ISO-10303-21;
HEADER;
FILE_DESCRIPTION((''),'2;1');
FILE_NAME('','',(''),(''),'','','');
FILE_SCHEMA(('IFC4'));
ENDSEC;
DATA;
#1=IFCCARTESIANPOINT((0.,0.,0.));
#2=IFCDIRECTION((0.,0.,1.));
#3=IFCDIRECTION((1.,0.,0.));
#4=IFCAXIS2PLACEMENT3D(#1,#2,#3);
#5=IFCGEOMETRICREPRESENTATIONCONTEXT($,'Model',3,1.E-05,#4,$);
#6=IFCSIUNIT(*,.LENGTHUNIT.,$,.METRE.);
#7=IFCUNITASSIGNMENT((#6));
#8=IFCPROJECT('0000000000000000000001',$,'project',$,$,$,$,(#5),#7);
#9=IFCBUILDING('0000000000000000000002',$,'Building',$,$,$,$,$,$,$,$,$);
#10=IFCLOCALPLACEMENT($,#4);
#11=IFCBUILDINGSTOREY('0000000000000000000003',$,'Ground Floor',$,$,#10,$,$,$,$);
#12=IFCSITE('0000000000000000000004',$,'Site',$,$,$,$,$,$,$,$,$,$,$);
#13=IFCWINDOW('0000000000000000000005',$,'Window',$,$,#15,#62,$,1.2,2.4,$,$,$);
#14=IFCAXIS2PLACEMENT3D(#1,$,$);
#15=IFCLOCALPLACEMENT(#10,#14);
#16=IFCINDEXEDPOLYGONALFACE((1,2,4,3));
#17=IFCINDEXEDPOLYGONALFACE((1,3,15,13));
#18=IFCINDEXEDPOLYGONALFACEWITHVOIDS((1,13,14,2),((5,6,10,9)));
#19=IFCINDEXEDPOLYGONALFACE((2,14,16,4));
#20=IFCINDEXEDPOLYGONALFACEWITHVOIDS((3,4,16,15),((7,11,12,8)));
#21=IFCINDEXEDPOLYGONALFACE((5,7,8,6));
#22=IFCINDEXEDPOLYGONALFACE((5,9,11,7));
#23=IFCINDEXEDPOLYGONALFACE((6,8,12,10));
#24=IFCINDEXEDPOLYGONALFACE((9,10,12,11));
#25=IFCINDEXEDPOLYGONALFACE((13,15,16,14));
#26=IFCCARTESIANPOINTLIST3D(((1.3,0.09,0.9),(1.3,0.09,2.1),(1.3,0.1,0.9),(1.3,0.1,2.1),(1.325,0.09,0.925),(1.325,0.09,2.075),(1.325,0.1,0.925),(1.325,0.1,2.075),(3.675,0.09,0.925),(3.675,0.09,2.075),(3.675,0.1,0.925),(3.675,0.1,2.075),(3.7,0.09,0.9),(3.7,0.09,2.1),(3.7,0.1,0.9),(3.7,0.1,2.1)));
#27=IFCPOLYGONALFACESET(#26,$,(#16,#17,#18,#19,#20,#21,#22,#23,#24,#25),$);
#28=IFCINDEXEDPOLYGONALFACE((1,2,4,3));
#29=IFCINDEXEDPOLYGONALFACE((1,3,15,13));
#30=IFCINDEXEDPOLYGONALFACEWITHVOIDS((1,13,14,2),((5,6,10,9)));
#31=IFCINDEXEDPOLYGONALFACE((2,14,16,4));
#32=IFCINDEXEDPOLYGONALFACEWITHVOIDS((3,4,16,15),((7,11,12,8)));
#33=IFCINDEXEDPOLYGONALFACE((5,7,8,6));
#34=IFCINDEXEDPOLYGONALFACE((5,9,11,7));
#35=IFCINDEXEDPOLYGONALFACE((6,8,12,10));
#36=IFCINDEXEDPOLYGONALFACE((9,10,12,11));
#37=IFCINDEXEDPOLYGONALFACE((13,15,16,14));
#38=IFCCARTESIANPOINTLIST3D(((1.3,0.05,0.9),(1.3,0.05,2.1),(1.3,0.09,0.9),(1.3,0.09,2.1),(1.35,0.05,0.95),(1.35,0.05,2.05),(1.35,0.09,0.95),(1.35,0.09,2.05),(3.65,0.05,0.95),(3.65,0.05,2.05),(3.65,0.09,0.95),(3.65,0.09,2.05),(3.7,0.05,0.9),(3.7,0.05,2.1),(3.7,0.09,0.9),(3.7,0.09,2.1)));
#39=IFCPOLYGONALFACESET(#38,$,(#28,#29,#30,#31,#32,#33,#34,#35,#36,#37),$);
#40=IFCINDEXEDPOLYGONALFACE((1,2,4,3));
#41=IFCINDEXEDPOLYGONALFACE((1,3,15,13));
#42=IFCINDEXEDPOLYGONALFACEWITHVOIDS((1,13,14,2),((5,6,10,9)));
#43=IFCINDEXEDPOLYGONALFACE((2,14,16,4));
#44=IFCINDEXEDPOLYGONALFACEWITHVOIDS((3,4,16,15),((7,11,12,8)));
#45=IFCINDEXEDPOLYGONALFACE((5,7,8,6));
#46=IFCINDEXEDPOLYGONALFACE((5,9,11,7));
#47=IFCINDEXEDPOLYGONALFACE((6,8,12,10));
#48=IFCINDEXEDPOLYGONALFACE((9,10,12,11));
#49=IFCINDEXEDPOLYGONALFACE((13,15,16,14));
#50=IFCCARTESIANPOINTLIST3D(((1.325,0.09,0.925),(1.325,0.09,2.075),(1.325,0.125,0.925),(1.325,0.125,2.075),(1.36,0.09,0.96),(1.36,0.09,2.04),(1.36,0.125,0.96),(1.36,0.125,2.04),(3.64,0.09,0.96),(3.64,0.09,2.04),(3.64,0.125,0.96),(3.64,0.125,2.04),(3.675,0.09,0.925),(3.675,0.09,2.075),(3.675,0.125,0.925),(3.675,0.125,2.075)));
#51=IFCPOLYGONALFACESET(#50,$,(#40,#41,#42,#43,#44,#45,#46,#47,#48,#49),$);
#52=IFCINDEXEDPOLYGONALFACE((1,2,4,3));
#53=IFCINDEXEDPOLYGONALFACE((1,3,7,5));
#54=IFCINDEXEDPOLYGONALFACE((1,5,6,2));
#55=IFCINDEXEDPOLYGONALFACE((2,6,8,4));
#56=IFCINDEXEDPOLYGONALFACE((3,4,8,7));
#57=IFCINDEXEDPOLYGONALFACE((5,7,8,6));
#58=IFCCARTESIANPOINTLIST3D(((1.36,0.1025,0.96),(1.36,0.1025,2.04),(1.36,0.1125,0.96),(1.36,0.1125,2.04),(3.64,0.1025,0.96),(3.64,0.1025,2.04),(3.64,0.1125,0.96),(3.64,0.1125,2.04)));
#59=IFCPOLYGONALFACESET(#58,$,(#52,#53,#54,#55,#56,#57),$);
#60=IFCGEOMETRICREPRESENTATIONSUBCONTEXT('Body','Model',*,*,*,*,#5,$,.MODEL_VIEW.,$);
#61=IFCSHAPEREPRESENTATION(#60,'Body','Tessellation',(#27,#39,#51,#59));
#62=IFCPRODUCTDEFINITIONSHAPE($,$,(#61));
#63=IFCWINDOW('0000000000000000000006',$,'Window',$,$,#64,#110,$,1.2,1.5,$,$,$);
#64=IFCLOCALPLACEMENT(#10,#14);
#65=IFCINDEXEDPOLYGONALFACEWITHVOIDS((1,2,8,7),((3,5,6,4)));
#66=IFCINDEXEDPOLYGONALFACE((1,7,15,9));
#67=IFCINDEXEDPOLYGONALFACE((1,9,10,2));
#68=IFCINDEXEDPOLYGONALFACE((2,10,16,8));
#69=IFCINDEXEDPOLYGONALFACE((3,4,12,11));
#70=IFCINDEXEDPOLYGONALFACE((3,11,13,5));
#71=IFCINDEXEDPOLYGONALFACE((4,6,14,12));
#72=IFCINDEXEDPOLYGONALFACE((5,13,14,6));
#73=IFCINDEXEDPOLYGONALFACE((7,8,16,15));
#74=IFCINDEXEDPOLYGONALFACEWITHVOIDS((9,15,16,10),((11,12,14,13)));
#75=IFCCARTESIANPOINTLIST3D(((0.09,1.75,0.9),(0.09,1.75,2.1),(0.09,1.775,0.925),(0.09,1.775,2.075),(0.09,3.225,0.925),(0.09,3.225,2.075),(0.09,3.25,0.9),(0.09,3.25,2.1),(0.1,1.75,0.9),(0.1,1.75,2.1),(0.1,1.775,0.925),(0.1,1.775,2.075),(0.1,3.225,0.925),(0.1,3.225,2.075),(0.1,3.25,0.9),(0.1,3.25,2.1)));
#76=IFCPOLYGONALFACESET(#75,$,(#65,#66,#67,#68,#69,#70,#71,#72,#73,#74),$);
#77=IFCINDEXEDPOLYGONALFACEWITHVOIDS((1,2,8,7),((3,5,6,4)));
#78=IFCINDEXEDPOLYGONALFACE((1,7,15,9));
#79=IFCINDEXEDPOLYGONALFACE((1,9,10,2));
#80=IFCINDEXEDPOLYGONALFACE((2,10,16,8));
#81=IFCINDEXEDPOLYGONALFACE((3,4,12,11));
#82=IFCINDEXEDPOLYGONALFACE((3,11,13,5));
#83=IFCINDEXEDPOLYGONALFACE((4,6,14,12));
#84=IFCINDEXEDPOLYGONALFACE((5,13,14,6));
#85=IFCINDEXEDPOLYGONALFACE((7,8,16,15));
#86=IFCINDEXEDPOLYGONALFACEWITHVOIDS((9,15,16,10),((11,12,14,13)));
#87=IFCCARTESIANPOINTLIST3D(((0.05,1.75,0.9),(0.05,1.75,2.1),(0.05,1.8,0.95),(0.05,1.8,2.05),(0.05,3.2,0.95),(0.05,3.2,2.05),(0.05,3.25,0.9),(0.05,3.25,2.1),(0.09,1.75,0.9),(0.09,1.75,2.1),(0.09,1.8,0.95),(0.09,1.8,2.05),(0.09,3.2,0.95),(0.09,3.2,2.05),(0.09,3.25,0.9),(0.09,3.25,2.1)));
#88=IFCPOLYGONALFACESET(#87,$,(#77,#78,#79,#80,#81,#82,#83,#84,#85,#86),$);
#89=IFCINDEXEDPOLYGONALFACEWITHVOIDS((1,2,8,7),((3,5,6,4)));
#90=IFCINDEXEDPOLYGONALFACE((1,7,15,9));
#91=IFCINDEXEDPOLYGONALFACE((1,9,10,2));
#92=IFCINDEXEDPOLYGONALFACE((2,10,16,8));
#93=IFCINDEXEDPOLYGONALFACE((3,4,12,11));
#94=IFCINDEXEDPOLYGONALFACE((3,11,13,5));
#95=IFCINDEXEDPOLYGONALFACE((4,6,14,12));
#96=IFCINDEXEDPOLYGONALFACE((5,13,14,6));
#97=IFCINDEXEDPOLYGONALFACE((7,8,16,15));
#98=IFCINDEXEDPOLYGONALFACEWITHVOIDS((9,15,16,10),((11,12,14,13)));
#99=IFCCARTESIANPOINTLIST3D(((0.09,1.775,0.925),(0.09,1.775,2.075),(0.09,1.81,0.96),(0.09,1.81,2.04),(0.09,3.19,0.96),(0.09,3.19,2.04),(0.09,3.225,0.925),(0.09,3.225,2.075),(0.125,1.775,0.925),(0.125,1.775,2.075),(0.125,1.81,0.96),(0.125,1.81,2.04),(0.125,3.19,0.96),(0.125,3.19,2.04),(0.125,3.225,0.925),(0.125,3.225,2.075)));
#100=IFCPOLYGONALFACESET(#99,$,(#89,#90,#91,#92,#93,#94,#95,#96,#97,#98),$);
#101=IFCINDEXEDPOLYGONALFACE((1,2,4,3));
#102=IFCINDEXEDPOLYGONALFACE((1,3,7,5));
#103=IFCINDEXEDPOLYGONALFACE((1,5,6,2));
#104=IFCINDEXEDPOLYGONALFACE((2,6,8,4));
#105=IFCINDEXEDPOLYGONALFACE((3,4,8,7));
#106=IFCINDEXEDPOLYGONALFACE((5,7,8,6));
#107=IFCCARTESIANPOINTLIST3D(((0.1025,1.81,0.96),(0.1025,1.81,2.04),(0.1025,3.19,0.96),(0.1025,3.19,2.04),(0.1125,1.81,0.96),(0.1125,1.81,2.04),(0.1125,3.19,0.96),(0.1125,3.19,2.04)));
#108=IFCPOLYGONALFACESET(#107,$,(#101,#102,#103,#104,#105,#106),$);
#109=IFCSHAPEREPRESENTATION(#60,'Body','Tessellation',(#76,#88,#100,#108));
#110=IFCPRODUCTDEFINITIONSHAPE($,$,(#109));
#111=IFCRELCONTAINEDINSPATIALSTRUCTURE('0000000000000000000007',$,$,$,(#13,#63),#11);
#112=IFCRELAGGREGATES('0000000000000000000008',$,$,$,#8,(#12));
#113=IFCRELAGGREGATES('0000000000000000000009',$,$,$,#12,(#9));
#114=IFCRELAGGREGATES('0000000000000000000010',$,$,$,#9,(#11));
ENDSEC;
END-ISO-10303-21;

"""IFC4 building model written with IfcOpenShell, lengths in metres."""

from ifc_helpers import new_model, si_unit, frame, origin_with_axes, place, context, subcontext, project, spatial, line, indexed_curve, outline, extrude, element, save


model = new_model("IFC4")

# Units and contexts
model_context = context("Model", 3, precision=1e-05, world=origin_with_axes())
body_context = subcontext(model_context, "Body", "Model", "MODEL_VIEW")
ifc_project = project(units=[si_unit("LENGTHUNIT", "METRE")], contexts=[model_context])

# Site, building, storey
site = spatial("IfcSite", under=ifc_project, Name="Site")
building = spatial("IfcBuilding", under=site, Name="Building")
storey_placement = place(None, origin_with_axes())
storey = spatial("IfcBuildingStorey", under=building, at=storey_placement, Name="Ground Floor")

# Windows
window_1_placement = place(storey_placement, frame((1.3, 0.0, 0.9), z_axis=(0.0, 0.0, 1.0), x_axis=(1.0, 0.0, 0.0)))
element("IfcWindow", 1, at=window_1_placement, inside=storey, Name="Window", OverallHeight=1.2, OverallWidth=2.4, context=body_context, shape_type="SweptSolid", body=[
    extrude(outline(indexed_curve([(0.0, 0.0), (2.4, 0.0), (2.4, 1.2), (0.0, 1.2)], segments=[line(1, 2, 3, 4, 1)]), holes=[indexed_curve([(0.025, 0.025), (2.375, 0.025), (2.375, 1.175), (0.025, 1.175)], segments=[line(1, 2, 3, 4, 1)])]), frame((0.0, 0.09, 0.0), z_axis=(0.0, -1.0, 0.0), x_axis=(1.0, 0.0, 0.0)), (0.0, 0.0, -1.0), 0.01),
    extrude(outline(indexed_curve([(0.0, 0.0), (2.4, 0.0), (2.4, 1.2), (0.0, 1.2)], segments=[line(1, 2, 3, 4, 1)]), holes=[indexed_curve([(0.05, 0.05), (2.35, 0.05), (2.35, 1.15), (0.05, 1.15)], segments=[line(1, 2, 3, 4, 1)])]), frame((0.0, 0.05, 0.0), z_axis=(0.0, -1.0, 0.0), x_axis=(1.0, 0.0, 0.0)), (0.0, 0.0, -1.0), 0.04),
    extrude(outline(indexed_curve([(0.0, 0.0), (2.35, 0.0), (2.35, 1.15), (0.0, 1.15)], segments=[line(1, 2, 3, 4, 1)]), holes=[indexed_curve([(0.035, 0.035), (2.315, 0.035), (2.315, 1.115), (0.035, 1.115)], segments=[line(1, 2, 3, 4, 1)])]), frame((0.025, 0.09, 0.025), z_axis=(0.0, -1.0, 0.0), x_axis=(1.0, 0.0, 0.0)), (0.0, 0.0, -1.0), 0.035),
    extrude(outline(indexed_curve([(0.035, 0.035), (2.315, 0.035), (2.315, 1.115), (0.035, 1.115)], segments=[line(1, 2, 3, 4, 1)])), frame((0.025, 0.1025, 0.025), z_axis=(0.0, -1.0, 0.0), x_axis=(1.0, 0.0, 0.0)), (0.0, 0.0, -1.0), 0.01),
])
window_2_placement = place(storey_placement, frame((0.0, 3.25, 0.9), z_axis=(0.0, 0.0, 1.0), x_axis=(0.0, -1.0, 0.0)))
element("IfcWindow", 2, at=window_2_placement, inside=storey, Name="Window", OverallHeight=1.2, OverallWidth=1.5, context=body_context, shape_type="SweptSolid", body=[
    extrude(outline(indexed_curve([(0.0, 0.0), (1.5, 0.0), (1.5, 1.2), (0.0, 1.2)], segments=[line(1, 2, 3, 4, 1)]), holes=[indexed_curve([(0.025, 0.025), (1.475, 0.025), (1.475, 1.175), (0.025, 1.175)], segments=[line(1, 2, 3, 4, 1)])]), frame((0.0, 0.09, 0.0), z_axis=(0.0, -1.0, 0.0), x_axis=(1.0, 0.0, 0.0)), (0.0, 0.0, -1.0), 0.01),
    extrude(outline(indexed_curve([(0.0, 0.0), (1.5, 0.0), (1.5, 1.2), (0.0, 1.2)], segments=[line(1, 2, 3, 4, 1)]), holes=[indexed_curve([(0.05, 0.05), (1.45, 0.05), (1.45, 1.15), (0.05, 1.15)], segments=[line(1, 2, 3, 4, 1)])]), frame((0.0, 0.05, 0.0), z_axis=(0.0, -1.0, 0.0), x_axis=(1.0, 0.0, 0.0)), (0.0, 0.0, -1.0), 0.04),
    extrude(outline(indexed_curve([(0.0, 0.0), (1.45, 0.0), (1.45, 1.15), (0.0, 1.15)], segments=[line(1, 2, 3, 4, 1)]), holes=[indexed_curve([(0.035, 0.035), (1.415, 0.035), (1.415, 1.115), (0.035, 1.115)], segments=[line(1, 2, 3, 4, 1)])]), frame((0.025, 0.09, 0.025), z_axis=(0.0, -1.0, 0.0), x_axis=(1.0, 0.0, 0.0)), (0.0, 0.0, -1.0), 0.035),
    extrude(outline(indexed_curve([(0.035, 0.035), (1.415, 0.035), (1.415, 1.115), (0.035, 1.115)], segments=[line(1, 2, 3, 4, 1)])), frame((0.025, 0.1025, 0.025), z_axis=(0.0, -1.0, 0.0), x_axis=(1.0, 0.0, 0.0)), (0.0, 0.0, -1.0), 0.01),
])

save(model, "model.ifc")
